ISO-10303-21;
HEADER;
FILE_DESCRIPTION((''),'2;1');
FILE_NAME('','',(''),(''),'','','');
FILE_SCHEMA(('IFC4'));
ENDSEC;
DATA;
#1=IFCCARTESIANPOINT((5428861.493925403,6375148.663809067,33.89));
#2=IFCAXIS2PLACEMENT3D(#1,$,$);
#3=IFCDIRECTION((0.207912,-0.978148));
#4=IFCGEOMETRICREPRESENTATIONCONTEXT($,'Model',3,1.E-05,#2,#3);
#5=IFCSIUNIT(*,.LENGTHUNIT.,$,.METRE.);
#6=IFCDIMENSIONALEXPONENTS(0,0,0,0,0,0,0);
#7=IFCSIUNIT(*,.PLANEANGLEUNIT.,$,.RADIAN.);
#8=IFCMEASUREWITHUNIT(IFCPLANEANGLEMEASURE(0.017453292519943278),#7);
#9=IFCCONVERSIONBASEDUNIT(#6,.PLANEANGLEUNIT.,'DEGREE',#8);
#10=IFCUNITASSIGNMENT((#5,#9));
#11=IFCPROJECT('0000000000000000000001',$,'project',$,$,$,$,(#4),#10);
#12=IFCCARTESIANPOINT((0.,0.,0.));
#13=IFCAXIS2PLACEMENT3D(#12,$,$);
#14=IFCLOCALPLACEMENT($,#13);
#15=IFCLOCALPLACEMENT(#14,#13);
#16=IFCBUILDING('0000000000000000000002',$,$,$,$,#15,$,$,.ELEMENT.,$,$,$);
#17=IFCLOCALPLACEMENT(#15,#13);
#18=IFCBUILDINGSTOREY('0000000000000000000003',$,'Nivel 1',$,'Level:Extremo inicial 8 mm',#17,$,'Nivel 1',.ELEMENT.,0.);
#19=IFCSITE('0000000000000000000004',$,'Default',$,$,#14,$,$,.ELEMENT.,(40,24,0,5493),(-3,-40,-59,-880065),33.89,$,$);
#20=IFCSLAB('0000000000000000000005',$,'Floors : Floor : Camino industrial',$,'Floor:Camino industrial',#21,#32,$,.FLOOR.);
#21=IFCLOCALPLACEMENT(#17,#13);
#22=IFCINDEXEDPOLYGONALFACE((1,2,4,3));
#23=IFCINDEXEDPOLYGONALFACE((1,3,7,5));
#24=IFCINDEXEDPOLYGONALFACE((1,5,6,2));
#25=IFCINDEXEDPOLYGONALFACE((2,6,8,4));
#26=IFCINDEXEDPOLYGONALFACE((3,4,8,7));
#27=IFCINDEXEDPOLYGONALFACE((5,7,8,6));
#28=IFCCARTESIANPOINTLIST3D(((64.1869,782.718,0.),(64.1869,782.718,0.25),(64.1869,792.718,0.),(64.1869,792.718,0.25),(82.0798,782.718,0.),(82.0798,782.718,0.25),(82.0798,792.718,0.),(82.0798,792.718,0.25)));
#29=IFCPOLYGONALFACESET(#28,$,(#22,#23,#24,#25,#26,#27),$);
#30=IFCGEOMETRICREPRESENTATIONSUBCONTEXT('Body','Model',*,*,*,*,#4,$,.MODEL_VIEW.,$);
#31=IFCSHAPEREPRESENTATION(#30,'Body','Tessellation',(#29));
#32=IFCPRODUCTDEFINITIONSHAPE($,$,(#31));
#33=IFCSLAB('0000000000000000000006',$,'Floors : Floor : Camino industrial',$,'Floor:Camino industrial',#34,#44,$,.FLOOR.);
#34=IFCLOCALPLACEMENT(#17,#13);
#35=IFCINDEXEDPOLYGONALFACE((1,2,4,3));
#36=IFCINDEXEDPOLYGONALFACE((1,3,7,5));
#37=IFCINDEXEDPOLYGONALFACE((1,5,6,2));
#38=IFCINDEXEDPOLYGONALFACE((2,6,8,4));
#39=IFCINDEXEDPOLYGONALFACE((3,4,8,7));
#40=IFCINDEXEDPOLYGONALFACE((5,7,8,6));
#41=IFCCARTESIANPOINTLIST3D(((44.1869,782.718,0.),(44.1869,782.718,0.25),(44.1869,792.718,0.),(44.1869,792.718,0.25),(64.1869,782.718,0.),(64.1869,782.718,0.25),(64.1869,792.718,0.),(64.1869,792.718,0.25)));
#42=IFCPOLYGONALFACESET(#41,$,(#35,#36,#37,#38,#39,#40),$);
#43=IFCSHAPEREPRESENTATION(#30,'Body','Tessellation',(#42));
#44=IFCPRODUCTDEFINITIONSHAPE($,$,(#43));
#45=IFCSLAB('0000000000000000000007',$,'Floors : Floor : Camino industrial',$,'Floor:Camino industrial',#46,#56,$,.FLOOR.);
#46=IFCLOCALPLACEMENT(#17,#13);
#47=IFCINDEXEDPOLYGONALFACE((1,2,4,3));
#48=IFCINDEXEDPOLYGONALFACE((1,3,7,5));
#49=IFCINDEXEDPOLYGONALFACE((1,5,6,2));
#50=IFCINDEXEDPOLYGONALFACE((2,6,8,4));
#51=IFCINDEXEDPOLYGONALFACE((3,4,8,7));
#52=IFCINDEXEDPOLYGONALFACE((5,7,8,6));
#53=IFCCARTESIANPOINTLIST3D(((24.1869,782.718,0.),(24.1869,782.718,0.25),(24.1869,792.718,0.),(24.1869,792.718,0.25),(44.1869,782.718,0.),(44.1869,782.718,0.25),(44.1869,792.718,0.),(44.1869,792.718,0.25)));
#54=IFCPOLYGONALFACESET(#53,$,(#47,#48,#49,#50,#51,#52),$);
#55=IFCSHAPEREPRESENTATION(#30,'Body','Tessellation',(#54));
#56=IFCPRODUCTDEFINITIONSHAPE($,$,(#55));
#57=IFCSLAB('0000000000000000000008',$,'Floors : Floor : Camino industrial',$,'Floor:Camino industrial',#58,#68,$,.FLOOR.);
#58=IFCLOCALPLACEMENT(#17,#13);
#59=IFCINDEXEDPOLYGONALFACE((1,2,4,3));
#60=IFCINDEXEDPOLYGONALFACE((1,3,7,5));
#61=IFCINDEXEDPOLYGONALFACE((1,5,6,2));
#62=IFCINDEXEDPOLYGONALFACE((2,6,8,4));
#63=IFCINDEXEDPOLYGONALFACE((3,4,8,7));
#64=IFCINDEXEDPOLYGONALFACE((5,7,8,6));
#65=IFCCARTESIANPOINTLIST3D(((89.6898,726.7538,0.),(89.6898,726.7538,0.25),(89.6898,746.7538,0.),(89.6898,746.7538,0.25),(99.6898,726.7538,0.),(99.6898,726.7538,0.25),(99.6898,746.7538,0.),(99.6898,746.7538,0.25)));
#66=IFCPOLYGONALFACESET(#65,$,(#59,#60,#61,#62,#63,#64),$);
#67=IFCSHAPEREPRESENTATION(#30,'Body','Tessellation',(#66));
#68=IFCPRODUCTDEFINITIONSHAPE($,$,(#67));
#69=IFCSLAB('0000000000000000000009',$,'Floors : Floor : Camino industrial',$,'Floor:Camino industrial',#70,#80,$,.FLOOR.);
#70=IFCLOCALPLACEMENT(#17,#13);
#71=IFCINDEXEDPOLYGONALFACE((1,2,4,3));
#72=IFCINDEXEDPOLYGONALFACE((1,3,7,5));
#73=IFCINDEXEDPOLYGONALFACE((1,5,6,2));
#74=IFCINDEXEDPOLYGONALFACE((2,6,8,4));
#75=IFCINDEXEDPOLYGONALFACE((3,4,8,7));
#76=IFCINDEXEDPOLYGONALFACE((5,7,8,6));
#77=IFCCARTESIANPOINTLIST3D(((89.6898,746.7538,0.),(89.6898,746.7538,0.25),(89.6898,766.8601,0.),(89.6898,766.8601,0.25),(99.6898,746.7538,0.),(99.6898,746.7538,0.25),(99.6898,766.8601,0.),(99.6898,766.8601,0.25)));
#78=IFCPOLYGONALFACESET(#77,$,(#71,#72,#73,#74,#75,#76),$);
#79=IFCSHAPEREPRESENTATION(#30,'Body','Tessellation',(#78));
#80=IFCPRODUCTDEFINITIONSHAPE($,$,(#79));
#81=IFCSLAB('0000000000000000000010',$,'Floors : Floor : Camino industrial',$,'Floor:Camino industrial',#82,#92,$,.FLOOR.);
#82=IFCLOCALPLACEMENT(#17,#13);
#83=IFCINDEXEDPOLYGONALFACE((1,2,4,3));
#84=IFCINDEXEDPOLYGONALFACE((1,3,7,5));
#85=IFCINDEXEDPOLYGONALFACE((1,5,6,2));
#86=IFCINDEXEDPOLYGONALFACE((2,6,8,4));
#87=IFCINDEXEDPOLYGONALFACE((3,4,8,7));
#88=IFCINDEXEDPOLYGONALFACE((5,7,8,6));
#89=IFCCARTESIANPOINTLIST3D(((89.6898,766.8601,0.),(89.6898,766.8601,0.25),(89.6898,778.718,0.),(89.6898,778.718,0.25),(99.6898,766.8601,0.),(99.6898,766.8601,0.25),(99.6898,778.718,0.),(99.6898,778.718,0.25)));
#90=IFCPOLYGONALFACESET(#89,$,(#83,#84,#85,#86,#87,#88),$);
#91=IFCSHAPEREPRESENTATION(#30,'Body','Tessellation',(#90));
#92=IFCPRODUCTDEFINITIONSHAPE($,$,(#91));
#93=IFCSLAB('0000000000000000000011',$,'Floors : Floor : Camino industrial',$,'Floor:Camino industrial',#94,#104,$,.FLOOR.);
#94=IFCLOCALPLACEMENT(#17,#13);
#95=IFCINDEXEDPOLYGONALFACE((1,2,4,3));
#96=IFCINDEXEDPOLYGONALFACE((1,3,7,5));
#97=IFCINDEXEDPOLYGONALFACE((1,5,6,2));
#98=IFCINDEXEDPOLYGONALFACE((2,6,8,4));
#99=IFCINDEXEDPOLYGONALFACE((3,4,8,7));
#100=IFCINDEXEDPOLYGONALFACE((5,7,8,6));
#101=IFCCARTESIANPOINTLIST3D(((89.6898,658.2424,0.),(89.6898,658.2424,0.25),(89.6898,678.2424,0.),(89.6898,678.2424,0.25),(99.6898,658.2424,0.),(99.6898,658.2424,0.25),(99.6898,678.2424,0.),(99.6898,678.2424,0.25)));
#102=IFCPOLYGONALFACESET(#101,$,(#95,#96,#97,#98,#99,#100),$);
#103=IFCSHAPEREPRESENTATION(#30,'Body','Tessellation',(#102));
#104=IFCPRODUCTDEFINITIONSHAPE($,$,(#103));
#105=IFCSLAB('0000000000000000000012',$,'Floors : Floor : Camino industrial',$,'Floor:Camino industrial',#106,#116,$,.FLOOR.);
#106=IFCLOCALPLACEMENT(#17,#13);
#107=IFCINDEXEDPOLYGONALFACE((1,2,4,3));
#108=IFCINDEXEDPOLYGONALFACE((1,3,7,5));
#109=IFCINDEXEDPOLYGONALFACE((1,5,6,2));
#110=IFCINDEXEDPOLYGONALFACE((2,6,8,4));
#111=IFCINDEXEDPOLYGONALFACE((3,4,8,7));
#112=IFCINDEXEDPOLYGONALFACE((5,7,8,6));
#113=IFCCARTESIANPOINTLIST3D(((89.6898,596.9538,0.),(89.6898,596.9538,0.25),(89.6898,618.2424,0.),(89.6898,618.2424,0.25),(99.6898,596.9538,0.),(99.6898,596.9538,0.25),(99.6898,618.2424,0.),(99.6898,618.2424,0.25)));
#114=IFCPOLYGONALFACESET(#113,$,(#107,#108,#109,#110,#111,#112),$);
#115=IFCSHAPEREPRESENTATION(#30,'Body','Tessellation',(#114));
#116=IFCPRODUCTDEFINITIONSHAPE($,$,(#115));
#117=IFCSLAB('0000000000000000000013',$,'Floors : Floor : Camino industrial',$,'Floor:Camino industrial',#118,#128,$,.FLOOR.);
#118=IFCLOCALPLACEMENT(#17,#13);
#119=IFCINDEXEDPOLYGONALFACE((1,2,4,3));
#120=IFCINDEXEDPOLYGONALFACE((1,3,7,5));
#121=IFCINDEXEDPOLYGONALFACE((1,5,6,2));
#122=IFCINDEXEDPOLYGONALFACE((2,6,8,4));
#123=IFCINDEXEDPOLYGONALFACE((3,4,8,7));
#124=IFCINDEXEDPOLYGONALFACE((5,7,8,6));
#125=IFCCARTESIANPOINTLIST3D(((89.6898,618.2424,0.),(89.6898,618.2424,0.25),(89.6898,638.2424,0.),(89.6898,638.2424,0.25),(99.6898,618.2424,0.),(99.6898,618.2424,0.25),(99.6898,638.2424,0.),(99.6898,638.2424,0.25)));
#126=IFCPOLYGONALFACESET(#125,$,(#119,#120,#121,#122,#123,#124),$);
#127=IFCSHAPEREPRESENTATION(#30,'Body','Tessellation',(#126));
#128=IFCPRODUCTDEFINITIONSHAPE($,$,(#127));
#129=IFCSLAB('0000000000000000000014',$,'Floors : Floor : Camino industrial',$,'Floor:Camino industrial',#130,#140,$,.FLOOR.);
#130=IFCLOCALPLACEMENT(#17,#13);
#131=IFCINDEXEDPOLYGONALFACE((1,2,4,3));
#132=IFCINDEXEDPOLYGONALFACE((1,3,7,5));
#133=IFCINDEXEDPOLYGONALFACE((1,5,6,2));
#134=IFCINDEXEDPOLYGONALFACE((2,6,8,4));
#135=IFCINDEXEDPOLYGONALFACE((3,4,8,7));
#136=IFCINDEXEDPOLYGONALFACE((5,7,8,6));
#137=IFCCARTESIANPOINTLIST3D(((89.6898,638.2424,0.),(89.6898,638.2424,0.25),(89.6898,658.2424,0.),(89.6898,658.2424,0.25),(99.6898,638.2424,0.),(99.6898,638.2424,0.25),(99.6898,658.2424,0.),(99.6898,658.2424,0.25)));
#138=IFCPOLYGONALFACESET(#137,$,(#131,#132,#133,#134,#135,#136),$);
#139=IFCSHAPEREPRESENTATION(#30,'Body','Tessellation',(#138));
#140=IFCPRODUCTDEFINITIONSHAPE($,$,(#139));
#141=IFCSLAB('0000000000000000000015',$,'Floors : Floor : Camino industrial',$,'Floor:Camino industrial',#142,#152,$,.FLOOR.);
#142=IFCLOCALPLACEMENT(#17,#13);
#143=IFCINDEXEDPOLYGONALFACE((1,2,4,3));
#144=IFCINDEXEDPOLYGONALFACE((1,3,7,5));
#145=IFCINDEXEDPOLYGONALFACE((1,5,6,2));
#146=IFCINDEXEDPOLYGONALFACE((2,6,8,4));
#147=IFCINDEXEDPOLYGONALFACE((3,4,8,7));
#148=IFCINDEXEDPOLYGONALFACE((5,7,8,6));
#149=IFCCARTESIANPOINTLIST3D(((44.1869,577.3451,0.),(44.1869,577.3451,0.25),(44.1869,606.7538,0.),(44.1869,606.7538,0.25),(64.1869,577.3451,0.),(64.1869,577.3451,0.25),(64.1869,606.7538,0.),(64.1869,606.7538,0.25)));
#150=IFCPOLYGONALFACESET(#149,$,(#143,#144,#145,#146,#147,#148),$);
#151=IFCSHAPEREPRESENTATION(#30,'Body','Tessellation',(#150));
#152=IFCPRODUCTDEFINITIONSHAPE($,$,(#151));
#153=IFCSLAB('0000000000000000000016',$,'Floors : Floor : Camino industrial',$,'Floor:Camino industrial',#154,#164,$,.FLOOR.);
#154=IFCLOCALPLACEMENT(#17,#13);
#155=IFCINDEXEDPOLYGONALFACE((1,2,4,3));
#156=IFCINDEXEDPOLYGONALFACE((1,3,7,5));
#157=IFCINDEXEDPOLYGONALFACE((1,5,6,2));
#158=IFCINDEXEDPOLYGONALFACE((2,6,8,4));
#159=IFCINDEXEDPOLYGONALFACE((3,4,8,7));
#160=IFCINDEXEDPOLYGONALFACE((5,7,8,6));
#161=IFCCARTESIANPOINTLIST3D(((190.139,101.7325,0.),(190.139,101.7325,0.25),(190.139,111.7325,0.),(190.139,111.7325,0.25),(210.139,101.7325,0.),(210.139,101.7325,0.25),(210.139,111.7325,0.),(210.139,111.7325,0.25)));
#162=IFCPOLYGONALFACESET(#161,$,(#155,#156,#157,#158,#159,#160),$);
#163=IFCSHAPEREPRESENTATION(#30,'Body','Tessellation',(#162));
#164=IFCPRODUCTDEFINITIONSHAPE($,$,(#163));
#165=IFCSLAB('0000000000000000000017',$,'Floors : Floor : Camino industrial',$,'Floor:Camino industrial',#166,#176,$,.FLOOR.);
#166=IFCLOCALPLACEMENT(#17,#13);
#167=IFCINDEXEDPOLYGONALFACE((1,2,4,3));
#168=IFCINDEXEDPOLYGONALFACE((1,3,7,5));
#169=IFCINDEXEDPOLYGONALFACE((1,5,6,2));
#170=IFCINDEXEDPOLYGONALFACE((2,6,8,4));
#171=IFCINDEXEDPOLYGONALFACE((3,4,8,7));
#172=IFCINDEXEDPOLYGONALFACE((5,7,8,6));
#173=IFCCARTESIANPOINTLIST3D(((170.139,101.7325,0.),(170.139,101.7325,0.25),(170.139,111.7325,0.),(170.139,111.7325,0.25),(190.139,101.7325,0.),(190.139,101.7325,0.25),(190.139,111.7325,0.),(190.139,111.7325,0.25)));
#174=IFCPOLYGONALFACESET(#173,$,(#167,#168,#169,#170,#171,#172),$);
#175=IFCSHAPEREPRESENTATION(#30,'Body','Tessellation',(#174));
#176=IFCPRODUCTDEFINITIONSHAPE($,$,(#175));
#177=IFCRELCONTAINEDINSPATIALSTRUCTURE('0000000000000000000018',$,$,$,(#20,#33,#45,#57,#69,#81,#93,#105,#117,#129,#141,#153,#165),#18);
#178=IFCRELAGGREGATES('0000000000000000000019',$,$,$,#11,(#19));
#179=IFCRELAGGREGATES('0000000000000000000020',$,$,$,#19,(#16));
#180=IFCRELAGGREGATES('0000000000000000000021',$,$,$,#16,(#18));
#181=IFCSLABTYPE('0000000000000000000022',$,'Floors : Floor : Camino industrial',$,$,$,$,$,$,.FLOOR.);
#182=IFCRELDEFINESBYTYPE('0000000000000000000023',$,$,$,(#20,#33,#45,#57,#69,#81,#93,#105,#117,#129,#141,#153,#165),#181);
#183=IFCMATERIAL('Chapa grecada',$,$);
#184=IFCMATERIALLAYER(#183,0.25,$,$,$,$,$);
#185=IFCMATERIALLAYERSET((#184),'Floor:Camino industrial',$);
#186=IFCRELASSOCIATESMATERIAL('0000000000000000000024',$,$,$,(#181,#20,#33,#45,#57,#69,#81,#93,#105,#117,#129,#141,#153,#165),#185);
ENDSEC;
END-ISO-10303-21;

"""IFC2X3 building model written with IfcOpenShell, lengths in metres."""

from ifc_helpers import new_model, entity, si_unit, converted_unit, direction, frame, frame_2d, origin, origin_2d_with_axis, place, context, subcontext, project, spatial, rectangle, extrude, material, layer, layer_set, layer_usage, type_object, element, save


model = new_model("IFC2X3")

# Units and contexts
model_context = context("Model", 3, precision=1e-05, world=frame((5428861.493925403, 6375148.663809067, 33.89)), true_north=direction((0.207912, -0.978148)))
body_context = subcontext(model_context, "Body", "Model", "MODEL_VIEW")
ifc_project = project(units=[si_unit("LENGTHUNIT", "METRE"), converted_unit("PLANEANGLEUNIT", "DEGREE", entity("IfcPlaneAngleMeasure", 0.017453292519943278), si_unit("PLANEANGLEUNIT", "RADIAN"), dimensions=[0, 0, 0, 0, 0, 0, 0])], contexts=[model_context])

# Site, building, storey
site_placement = place(None, origin())
site = spatial("IfcSite", under=ifc_project, at=site_placement, Name="Default", CompositionType="ELEMENT", RefLatitude=(40, 24, 0, 5493), RefLongitude=(-3, -40, -59, -880065), RefElevation=33.89)
building_placement = place(site_placement, origin())
building = spatial("IfcBuilding", under=site, at=building_placement, CompositionType="ELEMENT")
storey_placement = place(building_placement, origin())
storey = spatial("IfcBuildingStorey", under=building, at=storey_placement, Name="Nivel 1", ObjectType="Level:Extremo inicial 8 mm", LongName="Nivel 1", CompositionType="ELEMENT", Elevation=0.0)

# Slabs
ifc_material = material(Name="Chapa grecada")
ifc_layer = layer(ifc_material, 0.25)
ifc_layer_set = layer_set([ifc_layer], Name="Floor:Camino industrial")
ifc_layer_usage_1 = layer_usage(ifc_layer_set, "AXIS3", "POSITIVE", 0.0)
slab_type = type_object("IfcSlabType", Name="Floors : Floor : Camino industrial", PredefinedType="FLOOR", material=ifc_layer_set)
slab_1_placement = place(storey_placement, origin())
element("IfcSlab", 1, at=slab_1_placement, inside=storey, type_object=slab_type, material=ifc_layer_usage_1, Name="Floors : Floor : Camino industrial", ObjectType="Floor:Camino industrial", PredefinedType="FLOOR", context=body_context, shape_type="SweptSolid", body=[
    extrude(rectangle(XDim=10.0, YDim=17.8928, at=frame_2d((0.0, 0.0), x_axis=(1.0, 0.0))), frame((73.1334, 787.718, 0.25), z_axis=(0.0, 0.0, -1.0), x_axis=(0.0, 1.0, 0.0)), (0.0, 0.0, 1.0), 0.25),
])
ifc_layer_usage_2 = layer_usage(ifc_layer_set, "AXIS3", "POSITIVE", 0.0)
slab_2_placement = place(storey_placement, origin())
element("IfcSlab", 2, at=slab_2_placement, inside=storey, type_object=slab_type, material=ifc_layer_usage_2, Name="Floors : Floor : Camino industrial", ObjectType="Floor:Camino industrial", PredefinedType="FLOOR", context=body_context, shape_type="SweptSolid", body=[
    extrude(rectangle(XDim=10.0, YDim=20.0, at=frame_2d((0.0, 0.0), x_axis=(1.0, 0.0))), frame((54.1869, 787.718, 0.25), z_axis=(0.0, 0.0, -1.0), x_axis=(0.0, 1.0, 0.0)), (0.0, 0.0, 1.0), 0.25),
])
ifc_layer_usage_3 = layer_usage(ifc_layer_set, "AXIS3", "POSITIVE", 0.0)
slab_3_placement = place(storey_placement, origin())
element("IfcSlab", 3, at=slab_3_placement, inside=storey, type_object=slab_type, material=ifc_layer_usage_3, Name="Floors : Floor : Camino industrial", ObjectType="Floor:Camino industrial", PredefinedType="FLOOR", context=body_context, shape_type="SweptSolid", body=[
    extrude(rectangle(XDim=10.0, YDim=20.0, at=frame_2d((0.0, 0.0), x_axis=(1.0, 0.0))), frame((34.1869, 787.718, 0.25), z_axis=(0.0, 0.0, -1.0), x_axis=(0.0, 1.0, 0.0)), (0.0, 0.0, 1.0), 0.25),
])
ifc_layer_usage_4 = layer_usage(ifc_layer_set, "AXIS3", "POSITIVE", 0.0)
slab_4_placement = place(storey_placement, origin())
element("IfcSlab", 4, at=slab_4_placement, inside=storey, type_object=slab_type, material=ifc_layer_usage_4, Name="Floors : Floor : Camino industrial", ObjectType="Floor:Camino industrial", PredefinedType="FLOOR", context=body_context, shape_type="SweptSolid", body=[
    extrude(rectangle(XDim=20.0, YDim=10.0, at=frame_2d((0.0, 0.0), x_axis=(1.0, 0.0))), frame((94.6898, 736.7538, 0.25), z_axis=(0.0, 0.0, -1.0), x_axis=(0.0, 1.0, 0.0)), (0.0, 0.0, 1.0), 0.25),
])
ifc_layer_usage_5 = layer_usage(ifc_layer_set, "AXIS3", "POSITIVE", 0.0)
slab_5_placement = place(storey_placement, origin())
element("IfcSlab", 5, at=slab_5_placement, inside=storey, type_object=slab_type, material=ifc_layer_usage_5, Name="Floors : Floor : Camino industrial", ObjectType="Floor:Camino industrial", PredefinedType="FLOOR", context=body_context, shape_type="SweptSolid", body=[
    extrude(rectangle(XDim=20.1063, YDim=10.0, at=origin_2d_with_axis()), frame((94.6898, 756.8069, 0.25), z_axis=(0.0, 0.0, -1.0), x_axis=(0.0, 1.0, 0.0)), (0.0, 0.0, 1.0), 0.25),
])
ifc_layer_usage_6 = layer_usage(ifc_layer_set, "AXIS3", "POSITIVE", 0.0)
slab_6_placement = place(storey_placement, origin())
element("IfcSlab", 6, at=slab_6_placement, inside=storey, type_object=slab_type, material=ifc_layer_usage_6, Name="Floors : Floor : Camino industrial", ObjectType="Floor:Camino industrial", PredefinedType="FLOOR", context=body_context, shape_type="SweptSolid", body=[
    extrude(rectangle(XDim=11.8579, YDim=10.0, at=frame_2d((0.0, 0.0), x_axis=(1.0, 0.0))), frame((94.6898, 772.789, 0.25), z_axis=(0.0, 0.0, -1.0), x_axis=(0.0, 1.0, 0.0)), (0.0, 0.0, 1.0), 0.25),
])
ifc_layer_usage_7 = layer_usage(ifc_layer_set, "AXIS3", "POSITIVE", 0.0)
slab_7_placement = place(storey_placement, origin())
element("IfcSlab", 7, at=slab_7_placement, inside=storey, type_object=slab_type, material=ifc_layer_usage_7, Name="Floors : Floor : Camino industrial", ObjectType="Floor:Camino industrial", PredefinedType="FLOOR", context=body_context, shape_type="SweptSolid", body=[
    extrude(rectangle(XDim=20.0, YDim=10.0, at=origin_2d_with_axis()), frame((94.6898, 668.2424, 0.25), z_axis=(0.0, 0.0, -1.0), x_axis=(0.0, 1.0, 0.0)), (0.0, 0.0, 1.0), 0.25),
])
ifc_layer_usage_8 = layer_usage(ifc_layer_set, "AXIS3", "POSITIVE", 0.0)
slab_8_placement = place(storey_placement, origin())
element("IfcSlab", 8, at=slab_8_placement, inside=storey, type_object=slab_type, material=ifc_layer_usage_8, Name="Floors : Floor : Camino industrial", ObjectType="Floor:Camino industrial", PredefinedType="FLOOR", context=body_context, shape_type="SweptSolid", body=[
    extrude(rectangle(XDim=21.2886, YDim=10.0, at=frame_2d((0.0, 0.0), x_axis=(1.0, 0.0))), frame((94.6898, 607.5981, 0.25), z_axis=(0.0, 0.0, -1.0), x_axis=(0.0, 1.0, 0.0)), (0.0, 0.0, 1.0), 0.25),
])
ifc_layer_usage_9 = layer_usage(ifc_layer_set, "AXIS3", "POSITIVE", 0.0)
slab_9_placement = place(storey_placement, origin())
element("IfcSlab", 9, at=slab_9_placement, inside=storey, type_object=slab_type, material=ifc_layer_usage_9, Name="Floors : Floor : Camino industrial", ObjectType="Floor:Camino industrial", PredefinedType="FLOOR", context=body_context, shape_type="SweptSolid", body=[
    extrude(rectangle(XDim=20.0, YDim=10.0, at=origin_2d_with_axis()), frame((94.6898, 628.2424, 0.25), z_axis=(0.0, 0.0, -1.0), x_axis=(0.0, 1.0, 0.0)), (0.0, 0.0, 1.0), 0.25),
])
ifc_layer_usage_10 = layer_usage(ifc_layer_set, "AXIS3", "POSITIVE", 0.0)
slab_10_placement = place(storey_placement, origin())
element("IfcSlab", 10, at=slab_10_placement, inside=storey, type_object=slab_type, material=ifc_layer_usage_10, Name="Floors : Floor : Camino industrial", ObjectType="Floor:Camino industrial", PredefinedType="FLOOR", context=body_context, shape_type="SweptSolid", body=[
    extrude(rectangle(XDim=20.0, YDim=10.0, at=origin_2d_with_axis()), frame((94.6898, 648.2424, 0.25), z_axis=(0.0, 0.0, -1.0), x_axis=(0.0, 1.0, 0.0)), (0.0, 0.0, 1.0), 0.25),
])
ifc_layer_usage_11 = layer_usage(ifc_layer_set, "AXIS3", "POSITIVE", 0.0)
slab_11_placement = place(storey_placement, origin())
element("IfcSlab", 11, at=slab_11_placement, inside=storey, type_object=slab_type, material=ifc_layer_usage_11, Name="Floors : Floor : Camino industrial", ObjectType="Floor:Camino industrial", PredefinedType="FLOOR", context=body_context, shape_type="SweptSolid", body=[
    extrude(rectangle(XDim=29.4087, YDim=20.0, at=frame_2d((0.0, 0.0), x_axis=(1.0, 0.0))), frame((54.1869, 592.0494, 0.25), z_axis=(0.0, 0.0, -1.0), x_axis=(0.0, 1.0, 0.0)), (0.0, 0.0, 1.0), 0.25),
])
ifc_layer_usage_12 = layer_usage(ifc_layer_set, "AXIS3", "POSITIVE", 0.0)
slab_12_placement = place(storey_placement, origin())
element("IfcSlab", 12, at=slab_12_placement, inside=storey, type_object=slab_type, material=ifc_layer_usage_12, Name="Floors : Floor : Camino industrial", ObjectType="Floor:Camino industrial", PredefinedType="FLOOR", context=body_context, shape_type="SweptSolid", body=[
    extrude(rectangle(XDim=10.0, YDim=20.0, at=origin_2d_with_axis()), frame((200.139, 106.7325, 0.25), z_axis=(0.0, 0.0, -1.0), x_axis=(0.0, 1.0, 0.0)), (0.0, 0.0, 1.0), 0.25),
])
ifc_layer_usage_13 = layer_usage(ifc_layer_set, "AXIS3", "POSITIVE", 0.0)
slab_13_placement = place(storey_placement, origin())
element("IfcSlab", 13, at=slab_13_placement, inside=storey, type_object=slab_type, material=ifc_layer_usage_13, Name="Floors : Floor : Camino industrial", ObjectType="Floor:Camino industrial", PredefinedType="FLOOR", context=body_context, shape_type="SweptSolid", body=[
    extrude(rectangle(XDim=10.0, YDim=20.0, at=frame_2d((0.0, 0.0), x_axis=(1.0, 0.0))), frame((180.139, 106.7325, 0.25), z_axis=(0.0, 0.0, -1.0), x_axis=(0.0, 1.0, 0.0)), (0.0, 0.0, 1.0), 0.25),
])

save(model, "model.ifc")
